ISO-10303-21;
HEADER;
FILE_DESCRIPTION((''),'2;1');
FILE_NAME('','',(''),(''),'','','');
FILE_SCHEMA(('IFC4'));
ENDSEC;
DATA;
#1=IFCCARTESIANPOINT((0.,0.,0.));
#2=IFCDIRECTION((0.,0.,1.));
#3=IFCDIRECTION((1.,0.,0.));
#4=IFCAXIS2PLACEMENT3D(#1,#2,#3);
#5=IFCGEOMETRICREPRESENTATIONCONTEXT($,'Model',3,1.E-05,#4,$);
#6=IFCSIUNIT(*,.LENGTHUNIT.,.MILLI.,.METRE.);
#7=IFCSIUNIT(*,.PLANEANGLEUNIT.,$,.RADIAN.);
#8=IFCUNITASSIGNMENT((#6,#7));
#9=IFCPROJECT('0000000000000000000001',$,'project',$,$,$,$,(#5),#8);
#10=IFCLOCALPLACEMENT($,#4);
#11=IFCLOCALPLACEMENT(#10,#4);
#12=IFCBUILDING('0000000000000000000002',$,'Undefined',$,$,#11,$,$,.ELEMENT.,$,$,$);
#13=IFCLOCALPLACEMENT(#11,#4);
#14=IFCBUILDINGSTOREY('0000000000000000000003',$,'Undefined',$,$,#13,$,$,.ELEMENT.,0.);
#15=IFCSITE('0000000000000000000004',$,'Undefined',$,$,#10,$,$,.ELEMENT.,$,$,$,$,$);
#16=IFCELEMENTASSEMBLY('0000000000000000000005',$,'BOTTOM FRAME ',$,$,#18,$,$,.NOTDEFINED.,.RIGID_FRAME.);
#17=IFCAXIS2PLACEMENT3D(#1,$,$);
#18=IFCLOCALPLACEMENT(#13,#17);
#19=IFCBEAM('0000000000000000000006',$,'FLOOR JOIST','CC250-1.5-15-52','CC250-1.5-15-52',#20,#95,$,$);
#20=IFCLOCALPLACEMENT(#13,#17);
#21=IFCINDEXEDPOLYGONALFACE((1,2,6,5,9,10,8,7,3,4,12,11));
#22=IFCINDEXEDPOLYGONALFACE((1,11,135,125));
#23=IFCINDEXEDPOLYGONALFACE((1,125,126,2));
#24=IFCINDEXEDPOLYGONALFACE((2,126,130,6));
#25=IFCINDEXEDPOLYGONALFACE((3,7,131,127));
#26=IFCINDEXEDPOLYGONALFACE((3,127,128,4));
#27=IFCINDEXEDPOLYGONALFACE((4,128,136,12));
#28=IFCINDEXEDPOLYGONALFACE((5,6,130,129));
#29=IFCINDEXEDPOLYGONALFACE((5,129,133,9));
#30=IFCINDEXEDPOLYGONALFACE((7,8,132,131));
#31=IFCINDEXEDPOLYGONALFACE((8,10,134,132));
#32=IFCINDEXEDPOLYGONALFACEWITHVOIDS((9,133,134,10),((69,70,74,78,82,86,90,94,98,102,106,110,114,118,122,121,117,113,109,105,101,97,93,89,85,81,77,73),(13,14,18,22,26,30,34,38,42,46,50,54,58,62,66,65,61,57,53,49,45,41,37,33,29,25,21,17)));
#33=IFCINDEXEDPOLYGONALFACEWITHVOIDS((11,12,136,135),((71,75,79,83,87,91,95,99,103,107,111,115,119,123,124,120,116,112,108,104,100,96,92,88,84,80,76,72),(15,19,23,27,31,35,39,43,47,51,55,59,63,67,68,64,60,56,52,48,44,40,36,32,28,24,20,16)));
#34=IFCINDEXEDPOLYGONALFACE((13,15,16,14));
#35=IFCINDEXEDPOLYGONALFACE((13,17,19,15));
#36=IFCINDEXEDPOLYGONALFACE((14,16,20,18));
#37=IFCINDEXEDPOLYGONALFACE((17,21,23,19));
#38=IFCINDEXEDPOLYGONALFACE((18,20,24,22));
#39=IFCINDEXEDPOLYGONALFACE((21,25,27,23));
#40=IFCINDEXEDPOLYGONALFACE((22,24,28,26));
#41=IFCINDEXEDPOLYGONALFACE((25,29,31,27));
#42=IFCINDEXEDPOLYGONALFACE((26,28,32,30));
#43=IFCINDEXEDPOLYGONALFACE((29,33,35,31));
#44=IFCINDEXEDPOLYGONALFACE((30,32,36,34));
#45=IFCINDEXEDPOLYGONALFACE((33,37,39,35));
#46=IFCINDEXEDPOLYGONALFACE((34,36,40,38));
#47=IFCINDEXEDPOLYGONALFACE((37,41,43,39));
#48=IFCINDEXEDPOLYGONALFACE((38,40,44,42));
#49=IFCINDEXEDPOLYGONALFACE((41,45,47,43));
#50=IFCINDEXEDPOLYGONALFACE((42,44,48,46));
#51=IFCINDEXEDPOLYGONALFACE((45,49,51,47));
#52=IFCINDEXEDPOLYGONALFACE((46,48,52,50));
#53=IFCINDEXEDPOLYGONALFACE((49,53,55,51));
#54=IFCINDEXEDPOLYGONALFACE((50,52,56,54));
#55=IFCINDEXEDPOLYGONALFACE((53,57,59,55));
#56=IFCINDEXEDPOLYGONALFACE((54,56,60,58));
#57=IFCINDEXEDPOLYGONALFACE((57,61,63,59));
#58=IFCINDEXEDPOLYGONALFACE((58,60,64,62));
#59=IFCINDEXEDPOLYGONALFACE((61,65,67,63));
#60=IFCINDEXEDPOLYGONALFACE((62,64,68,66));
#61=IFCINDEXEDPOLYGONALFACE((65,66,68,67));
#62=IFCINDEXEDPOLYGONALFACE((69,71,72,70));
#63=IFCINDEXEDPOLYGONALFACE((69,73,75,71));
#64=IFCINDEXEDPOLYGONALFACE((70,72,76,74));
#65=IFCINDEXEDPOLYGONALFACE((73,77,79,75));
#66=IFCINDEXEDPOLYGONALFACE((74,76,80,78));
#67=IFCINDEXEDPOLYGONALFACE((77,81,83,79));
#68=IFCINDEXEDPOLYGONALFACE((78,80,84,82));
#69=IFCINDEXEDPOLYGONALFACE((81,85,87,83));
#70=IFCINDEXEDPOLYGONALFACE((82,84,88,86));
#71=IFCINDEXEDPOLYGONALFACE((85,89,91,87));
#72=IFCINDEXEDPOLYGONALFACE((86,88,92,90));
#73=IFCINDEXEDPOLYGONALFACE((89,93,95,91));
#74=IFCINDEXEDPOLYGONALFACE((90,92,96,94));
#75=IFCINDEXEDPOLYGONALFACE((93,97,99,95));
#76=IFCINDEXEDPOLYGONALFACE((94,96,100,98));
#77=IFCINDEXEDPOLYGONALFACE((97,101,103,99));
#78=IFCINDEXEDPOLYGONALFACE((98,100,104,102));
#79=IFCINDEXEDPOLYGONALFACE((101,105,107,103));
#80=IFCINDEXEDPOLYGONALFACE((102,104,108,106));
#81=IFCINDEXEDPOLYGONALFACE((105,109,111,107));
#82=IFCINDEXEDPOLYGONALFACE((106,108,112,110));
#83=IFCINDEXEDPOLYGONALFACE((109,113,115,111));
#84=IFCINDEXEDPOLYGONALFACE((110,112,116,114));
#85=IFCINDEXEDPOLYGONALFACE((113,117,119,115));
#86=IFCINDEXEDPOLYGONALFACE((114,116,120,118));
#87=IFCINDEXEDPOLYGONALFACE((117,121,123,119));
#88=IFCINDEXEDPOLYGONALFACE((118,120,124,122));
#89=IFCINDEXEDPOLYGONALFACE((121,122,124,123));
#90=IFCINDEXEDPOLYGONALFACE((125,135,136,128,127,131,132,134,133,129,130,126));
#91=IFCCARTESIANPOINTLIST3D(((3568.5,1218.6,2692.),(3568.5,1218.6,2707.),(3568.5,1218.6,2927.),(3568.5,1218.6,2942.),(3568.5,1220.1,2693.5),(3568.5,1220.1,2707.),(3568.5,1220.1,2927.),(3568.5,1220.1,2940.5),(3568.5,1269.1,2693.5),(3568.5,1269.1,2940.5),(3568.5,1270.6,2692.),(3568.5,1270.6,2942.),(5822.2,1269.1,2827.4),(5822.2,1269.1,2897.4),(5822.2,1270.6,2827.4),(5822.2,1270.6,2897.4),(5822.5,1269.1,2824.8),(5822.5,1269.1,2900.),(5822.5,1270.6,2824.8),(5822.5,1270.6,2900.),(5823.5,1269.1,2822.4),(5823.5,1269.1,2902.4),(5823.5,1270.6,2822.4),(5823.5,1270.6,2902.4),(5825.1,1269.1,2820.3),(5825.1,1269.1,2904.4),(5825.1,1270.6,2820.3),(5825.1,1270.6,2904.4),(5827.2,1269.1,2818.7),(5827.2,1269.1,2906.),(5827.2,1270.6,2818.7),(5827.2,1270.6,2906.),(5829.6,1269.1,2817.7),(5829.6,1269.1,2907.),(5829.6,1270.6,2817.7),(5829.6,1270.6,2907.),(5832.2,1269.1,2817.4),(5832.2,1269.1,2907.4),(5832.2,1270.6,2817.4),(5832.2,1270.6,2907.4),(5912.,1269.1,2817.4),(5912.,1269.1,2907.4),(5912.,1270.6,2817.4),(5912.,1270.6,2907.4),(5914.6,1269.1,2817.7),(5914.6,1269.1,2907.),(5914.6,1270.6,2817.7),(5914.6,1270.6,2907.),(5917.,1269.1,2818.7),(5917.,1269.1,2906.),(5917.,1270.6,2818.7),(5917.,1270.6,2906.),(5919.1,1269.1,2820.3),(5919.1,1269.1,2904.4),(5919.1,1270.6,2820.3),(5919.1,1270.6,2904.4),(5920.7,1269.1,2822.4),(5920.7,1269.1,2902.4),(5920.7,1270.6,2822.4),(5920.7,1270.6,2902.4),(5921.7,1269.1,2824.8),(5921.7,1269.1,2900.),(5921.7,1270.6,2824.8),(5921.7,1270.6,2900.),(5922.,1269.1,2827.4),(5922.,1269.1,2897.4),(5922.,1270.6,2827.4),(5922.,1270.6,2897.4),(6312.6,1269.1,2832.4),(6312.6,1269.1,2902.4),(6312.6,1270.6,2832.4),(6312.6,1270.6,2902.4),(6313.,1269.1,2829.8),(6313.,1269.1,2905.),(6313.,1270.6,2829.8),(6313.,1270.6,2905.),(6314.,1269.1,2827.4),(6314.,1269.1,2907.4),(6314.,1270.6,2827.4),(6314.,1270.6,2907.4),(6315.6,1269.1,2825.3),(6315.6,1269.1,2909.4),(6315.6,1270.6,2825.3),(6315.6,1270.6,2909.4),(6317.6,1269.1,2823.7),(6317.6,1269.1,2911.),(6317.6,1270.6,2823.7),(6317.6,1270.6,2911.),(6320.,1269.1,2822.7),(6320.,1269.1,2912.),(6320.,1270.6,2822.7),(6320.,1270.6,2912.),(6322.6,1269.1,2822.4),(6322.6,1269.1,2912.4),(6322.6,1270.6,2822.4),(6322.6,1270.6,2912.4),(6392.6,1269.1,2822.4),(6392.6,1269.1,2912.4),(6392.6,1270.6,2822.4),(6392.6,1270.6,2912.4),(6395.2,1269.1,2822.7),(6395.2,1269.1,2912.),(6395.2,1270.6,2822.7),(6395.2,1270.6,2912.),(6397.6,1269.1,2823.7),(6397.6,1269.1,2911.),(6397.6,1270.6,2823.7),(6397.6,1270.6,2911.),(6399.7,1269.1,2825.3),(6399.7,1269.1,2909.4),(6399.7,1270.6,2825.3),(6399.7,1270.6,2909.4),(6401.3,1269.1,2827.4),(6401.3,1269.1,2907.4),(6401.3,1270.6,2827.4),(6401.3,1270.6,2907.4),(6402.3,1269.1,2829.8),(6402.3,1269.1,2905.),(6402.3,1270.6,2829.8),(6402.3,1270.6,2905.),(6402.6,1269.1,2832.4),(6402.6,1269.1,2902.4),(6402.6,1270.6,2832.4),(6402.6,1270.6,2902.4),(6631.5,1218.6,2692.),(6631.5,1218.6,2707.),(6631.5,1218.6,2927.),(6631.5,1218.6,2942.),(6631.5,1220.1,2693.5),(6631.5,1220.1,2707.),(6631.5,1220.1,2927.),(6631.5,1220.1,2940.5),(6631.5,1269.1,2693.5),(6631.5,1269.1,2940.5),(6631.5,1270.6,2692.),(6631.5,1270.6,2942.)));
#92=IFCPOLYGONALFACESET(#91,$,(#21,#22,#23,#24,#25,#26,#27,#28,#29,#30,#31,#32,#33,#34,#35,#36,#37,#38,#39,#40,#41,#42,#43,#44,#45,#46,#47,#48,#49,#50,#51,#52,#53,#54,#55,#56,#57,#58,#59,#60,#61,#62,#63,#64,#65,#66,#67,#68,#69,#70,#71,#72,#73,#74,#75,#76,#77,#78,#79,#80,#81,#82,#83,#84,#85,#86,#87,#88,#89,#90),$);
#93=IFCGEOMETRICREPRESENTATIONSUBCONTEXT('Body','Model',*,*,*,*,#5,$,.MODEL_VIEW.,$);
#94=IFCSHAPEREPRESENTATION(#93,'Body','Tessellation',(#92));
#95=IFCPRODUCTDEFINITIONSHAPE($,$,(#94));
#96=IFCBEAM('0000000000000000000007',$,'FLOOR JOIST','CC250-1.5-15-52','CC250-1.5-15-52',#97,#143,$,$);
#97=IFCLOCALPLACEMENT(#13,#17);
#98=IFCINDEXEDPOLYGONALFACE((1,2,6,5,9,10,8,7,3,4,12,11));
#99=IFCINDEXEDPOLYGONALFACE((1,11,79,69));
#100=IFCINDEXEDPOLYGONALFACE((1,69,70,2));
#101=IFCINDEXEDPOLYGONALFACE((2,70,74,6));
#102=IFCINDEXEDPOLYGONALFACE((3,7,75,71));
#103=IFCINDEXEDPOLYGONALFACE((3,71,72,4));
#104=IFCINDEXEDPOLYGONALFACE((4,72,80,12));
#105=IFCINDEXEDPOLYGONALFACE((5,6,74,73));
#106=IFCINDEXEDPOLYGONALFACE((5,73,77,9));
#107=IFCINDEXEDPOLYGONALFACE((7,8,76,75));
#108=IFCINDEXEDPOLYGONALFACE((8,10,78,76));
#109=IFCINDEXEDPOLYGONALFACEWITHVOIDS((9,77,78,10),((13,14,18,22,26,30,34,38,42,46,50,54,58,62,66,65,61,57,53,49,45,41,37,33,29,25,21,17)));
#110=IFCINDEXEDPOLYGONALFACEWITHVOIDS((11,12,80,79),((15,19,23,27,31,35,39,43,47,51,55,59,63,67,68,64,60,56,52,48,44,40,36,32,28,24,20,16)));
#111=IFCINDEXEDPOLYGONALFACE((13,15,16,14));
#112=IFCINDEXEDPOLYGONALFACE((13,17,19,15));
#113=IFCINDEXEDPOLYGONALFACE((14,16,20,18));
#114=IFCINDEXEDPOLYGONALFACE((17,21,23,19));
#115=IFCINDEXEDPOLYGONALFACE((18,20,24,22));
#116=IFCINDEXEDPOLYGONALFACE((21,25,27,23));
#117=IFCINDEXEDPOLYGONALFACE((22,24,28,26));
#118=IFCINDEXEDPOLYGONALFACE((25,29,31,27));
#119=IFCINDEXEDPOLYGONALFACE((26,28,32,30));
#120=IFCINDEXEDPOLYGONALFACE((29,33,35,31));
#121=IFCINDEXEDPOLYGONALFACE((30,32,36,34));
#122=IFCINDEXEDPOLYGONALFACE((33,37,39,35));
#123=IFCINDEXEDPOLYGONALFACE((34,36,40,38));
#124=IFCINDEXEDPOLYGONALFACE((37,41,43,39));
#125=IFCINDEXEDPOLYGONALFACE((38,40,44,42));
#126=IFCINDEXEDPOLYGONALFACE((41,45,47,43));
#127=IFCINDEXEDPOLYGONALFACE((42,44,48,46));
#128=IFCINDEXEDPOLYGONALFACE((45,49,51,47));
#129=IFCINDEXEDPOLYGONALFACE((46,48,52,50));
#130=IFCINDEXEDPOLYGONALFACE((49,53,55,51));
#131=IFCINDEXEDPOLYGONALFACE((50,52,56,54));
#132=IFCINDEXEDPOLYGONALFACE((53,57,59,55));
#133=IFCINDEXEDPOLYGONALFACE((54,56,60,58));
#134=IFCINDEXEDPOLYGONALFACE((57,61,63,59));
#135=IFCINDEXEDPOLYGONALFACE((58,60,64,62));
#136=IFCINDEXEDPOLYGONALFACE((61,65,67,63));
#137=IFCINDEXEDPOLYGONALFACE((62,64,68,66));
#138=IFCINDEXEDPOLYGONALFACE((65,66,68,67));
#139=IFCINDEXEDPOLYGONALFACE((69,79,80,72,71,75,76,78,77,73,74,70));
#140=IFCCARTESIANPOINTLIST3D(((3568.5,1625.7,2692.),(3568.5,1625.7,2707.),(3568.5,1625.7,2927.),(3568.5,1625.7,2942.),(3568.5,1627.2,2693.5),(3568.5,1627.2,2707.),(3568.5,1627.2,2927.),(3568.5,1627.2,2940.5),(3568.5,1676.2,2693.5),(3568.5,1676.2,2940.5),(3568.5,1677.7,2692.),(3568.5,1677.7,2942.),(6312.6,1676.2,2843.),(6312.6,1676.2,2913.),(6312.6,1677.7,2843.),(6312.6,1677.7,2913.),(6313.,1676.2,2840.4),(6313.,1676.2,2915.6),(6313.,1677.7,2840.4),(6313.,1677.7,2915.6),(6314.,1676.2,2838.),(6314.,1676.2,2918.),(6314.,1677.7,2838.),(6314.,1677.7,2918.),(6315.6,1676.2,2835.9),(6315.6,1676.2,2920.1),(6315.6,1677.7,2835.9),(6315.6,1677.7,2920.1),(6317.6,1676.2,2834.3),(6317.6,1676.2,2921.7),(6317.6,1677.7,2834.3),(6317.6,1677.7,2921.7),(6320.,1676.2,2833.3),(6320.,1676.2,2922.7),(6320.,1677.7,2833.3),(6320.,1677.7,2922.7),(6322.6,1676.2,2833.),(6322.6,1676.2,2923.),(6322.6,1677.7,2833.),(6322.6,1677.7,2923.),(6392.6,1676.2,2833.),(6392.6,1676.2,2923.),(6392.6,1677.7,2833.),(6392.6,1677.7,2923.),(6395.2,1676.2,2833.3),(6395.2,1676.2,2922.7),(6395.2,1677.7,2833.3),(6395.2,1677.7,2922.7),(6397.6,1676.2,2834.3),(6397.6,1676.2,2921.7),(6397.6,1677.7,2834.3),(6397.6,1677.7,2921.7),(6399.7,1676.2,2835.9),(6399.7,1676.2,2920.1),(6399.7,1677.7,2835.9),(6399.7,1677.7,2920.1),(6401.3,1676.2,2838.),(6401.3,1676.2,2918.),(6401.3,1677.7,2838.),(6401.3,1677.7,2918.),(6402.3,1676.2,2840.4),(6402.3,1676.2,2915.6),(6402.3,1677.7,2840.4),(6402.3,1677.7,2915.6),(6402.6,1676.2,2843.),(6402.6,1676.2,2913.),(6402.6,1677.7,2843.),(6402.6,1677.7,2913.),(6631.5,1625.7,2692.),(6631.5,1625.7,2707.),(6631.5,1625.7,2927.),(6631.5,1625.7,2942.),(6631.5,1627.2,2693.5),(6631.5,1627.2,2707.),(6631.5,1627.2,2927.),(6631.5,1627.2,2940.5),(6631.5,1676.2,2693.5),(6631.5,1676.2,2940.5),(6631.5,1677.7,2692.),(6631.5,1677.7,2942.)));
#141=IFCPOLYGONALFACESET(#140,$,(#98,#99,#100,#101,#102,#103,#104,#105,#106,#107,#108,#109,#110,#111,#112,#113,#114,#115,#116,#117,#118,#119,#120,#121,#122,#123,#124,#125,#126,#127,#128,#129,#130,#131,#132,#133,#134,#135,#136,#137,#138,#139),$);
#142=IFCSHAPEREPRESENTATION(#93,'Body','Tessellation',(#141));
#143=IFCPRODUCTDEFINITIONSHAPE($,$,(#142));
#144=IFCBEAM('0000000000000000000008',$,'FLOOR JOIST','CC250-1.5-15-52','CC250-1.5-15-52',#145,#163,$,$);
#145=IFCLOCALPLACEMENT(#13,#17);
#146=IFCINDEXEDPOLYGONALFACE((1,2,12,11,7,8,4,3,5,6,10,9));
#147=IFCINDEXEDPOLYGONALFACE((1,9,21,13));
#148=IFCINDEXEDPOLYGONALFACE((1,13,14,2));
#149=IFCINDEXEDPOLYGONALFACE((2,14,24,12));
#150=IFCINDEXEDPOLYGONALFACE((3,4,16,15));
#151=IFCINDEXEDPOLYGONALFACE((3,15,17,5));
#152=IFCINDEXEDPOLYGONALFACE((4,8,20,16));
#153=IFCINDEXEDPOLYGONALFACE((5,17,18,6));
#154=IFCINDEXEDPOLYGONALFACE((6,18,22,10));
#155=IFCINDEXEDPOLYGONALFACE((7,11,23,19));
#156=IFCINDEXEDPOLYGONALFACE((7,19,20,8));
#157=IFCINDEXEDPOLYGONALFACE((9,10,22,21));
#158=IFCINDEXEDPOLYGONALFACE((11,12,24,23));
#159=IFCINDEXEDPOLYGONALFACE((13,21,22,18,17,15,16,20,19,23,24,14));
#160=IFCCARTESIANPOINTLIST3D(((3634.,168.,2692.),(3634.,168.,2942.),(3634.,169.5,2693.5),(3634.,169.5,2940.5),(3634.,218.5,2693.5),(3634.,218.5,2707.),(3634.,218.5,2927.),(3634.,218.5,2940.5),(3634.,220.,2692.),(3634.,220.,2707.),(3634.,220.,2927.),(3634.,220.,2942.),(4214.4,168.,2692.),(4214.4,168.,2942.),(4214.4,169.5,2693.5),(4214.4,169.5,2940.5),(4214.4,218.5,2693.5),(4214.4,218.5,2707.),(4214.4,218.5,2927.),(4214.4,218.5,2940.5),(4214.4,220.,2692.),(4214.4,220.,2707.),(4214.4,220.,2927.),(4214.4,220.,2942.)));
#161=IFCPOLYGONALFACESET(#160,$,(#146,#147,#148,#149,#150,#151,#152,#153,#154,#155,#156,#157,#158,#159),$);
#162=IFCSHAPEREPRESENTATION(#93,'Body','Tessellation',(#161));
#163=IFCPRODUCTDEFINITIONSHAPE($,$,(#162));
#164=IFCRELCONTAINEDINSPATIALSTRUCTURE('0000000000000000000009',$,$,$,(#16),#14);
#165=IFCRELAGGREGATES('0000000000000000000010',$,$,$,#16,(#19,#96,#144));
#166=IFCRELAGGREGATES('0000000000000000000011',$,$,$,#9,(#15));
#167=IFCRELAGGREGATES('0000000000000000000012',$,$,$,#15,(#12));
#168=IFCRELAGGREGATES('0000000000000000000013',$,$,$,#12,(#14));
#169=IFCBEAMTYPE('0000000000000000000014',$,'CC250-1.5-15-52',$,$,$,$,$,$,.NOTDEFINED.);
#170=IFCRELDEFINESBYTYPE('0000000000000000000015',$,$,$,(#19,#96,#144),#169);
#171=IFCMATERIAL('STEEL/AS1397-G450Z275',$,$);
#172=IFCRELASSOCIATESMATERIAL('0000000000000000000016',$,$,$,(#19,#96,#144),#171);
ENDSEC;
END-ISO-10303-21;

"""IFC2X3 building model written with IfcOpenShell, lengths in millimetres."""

from ifc_helpers import new_model, si_unit, frame, frame_2d, origin_with_axes, origin_2d_with_axis, place, context, subcontext, project, spatial, polyline, circle_curve, parameter, trimmed, segment, composite_curve, c_section, outline, extrude, boolean, material, type_object, element, aggregate, save


model = new_model("IFC2X3")

# Units and contexts
model_context = context("Model", 3, precision=1e-05, world=origin_with_axes())
body_context = subcontext(model_context, "Body", "Model", "MODEL_VIEW")
ifc_project = project(units=[si_unit("LENGTHUNIT", "METRE", prefix="MILLI"), si_unit("PLANEANGLEUNIT", "RADIAN")], contexts=[model_context])

# Site, building, storey
site_placement = place(None, origin_with_axes())
site = spatial("IfcSite", under=ifc_project, at=site_placement, Name="Undefined", CompositionType="ELEMENT")
building_placement = place(site_placement, origin_with_axes())
building = spatial("IfcBuilding", under=site, at=building_placement, Name="Undefined", CompositionType="ELEMENT")
storey_placement = place(building_placement, origin_with_axes())
storey = spatial("IfcBuildingStorey", under=building, at=storey_placement, Name="Undefined", CompositionType="ELEMENT", Elevation=0.0)

# Element assembly, beams
assembly_1_placement = place(storey_placement, origin_with_axes())
assembly_1 = element("IfcElementAssembly", 1, at=assembly_1_placement, inside=storey, Name="BOTTOM FRAME ", AssemblyPlace="NOTDEFINED", PredefinedType="RIGID_FRAME")
ifc_material_1 = material(Name="STEEL/AS1397-G450Z275")
beam_type_1 = type_object("IfcBeamType", Name="CC250-1.5-15-52", PredefinedType="NOTDEFINED")
beam_1_placement = place(assembly_1_placement, frame((3568.5, 1244.6, 2817.0), z_axis=(0.0, 0.0, 1.0), x_axis=(1.0, 0.0, 0.0)))
beam_1 = element("IfcBeam", 2, at=beam_1_placement, type_object=beam_type_1, material=ifc_material_1, Name="FLOOR JOIST", Description="CC250-1.5-15-52", ObjectType="CC250-1.5-15-52", context=body_context, shape_type="CSG", body=[
    boolean("DIFFERENCE", boolean("DIFFERENCE", extrude(c_section(Depth=250.0, Width=52.0, WallThickness=1.5, Girth=15.0, at=origin_2d_with_axis()), frame((3063.0, 0.0, 0.0), z_axis=(-1.0, 0.0, 0.0), x_axis=(0.0, -1.0, 0.0)), (0.0, 0.0, 1.0), 3063.0), extrude(outline(composite_curve([segment(trimmed(circle_curve(frame_2d((10.0, 10.0), x_axis=(-1.0, 0.0)), 10.0), [parameter(0.0)], [parameter(1.570796)], True, "PARAMETER"), True, "CONTINUOUS"), segment(polyline([(10.0, 0.0), (89.8, 0.0)]), True, "CONTINUOUS"), segment(trimmed(circle_curve(frame_2d((89.8, 10.0), x_axis=(0.0, -1.0)), 10.0), [parameter(0.0)], [parameter(1.570796)], True, "PARAMETER"), True, "CONTINUOUS"), segment(polyline([(99.8, 10.0), (99.8, 80.0)]), True, "CONTINUOUS"), segment(trimmed(circle_curve(frame_2d((89.8, 80.0), x_axis=(1.0, 0.0)), 10.0), [parameter(0.0)], [parameter(1.570796)], True, "PARAMETER"), True, "CONTINUOUS"), segment(polyline([(89.8, 90.0), (10.0, 90.0)]), True, "CONTINUOUS"), segment(trimmed(circle_curve(frame_2d((10.0, 80.0), x_axis=(0.0, 1.0)), 10.0), [parameter(0.0)], [parameter(1.570796)], True, "PARAMETER"), True, "CONTINUOUS"), segment(polyline([(0.0, 80.0), (0.0, 10.0)]), True, "CONTINUOUS")], self_intersect=True)), frame((2253.7, -40.5, 90.4), z_axis=(0.0, 1.0, 0.0), x_axis=(1.0, 0.0, 0.0)), (0.0, 0.0, 1.0), 81.0)), extrude(outline(composite_curve([segment(trimmed(circle_curve(frame_2d((10.0, 10.0), x_axis=(-1.0, 0.0)), 10.0), [parameter(0.0)], [parameter(1.570796)], True, "PARAMETER"), True, "CONTINUOUS"), segment(polyline([(10.0, 0.0), (80.0, 0.0)]), True, "CONTINUOUS"), segment(trimmed(circle_curve(frame_2d((80.0, 10.0), x_axis=(0.0, -1.0)), 10.0), [parameter(0.0)], [parameter(1.570796)], True, "PARAMETER"), True, "CONTINUOUS"), segment(polyline([(90.0, 10.0), (90.0, 80.0)]), True, "CONTINUOUS"), segment(trimmed(circle_curve(frame_2d((80.0, 80.0), x_axis=(1.0, 0.0)), 10.0), [parameter(0.0)], [parameter(1.570796)], True, "PARAMETER"), True, "CONTINUOUS"), segment(polyline([(80.0, 90.0), (10.0, 90.0)]), True, "CONTINUOUS"), segment(trimmed(circle_curve(frame_2d((10.0, 80.0), x_axis=(0.0, 1.0)), 10.0), [parameter(0.0)], [parameter(1.570796)], True, "PARAMETER"), True, "CONTINUOUS"), segment(polyline([(0.0, 80.0), (0.0, 10.0)]), True, "CONTINUOUS")], self_intersect=True)), frame((2744.1, -40.5, 95.4), z_axis=(0.0, 1.0, 0.0), x_axis=(1.0, 0.0, 0.0)), (0.0, 0.0, 1.0), 81.0)),
])
beam_2_placement = place(assembly_1_placement, frame((3568.5, 1651.7, 2817.0), z_axis=(0.0, 0.0, 1.0), x_axis=(1.0, 0.0, 0.0)))
beam_2 = element("IfcBeam", 3, at=beam_2_placement, type_object=beam_type_1, material=ifc_material_1, Name="FLOOR JOIST", Description="CC250-1.5-15-52", ObjectType="CC250-1.5-15-52", context=body_context, shape_type="CSG", body=[
    boolean("DIFFERENCE", extrude(c_section(Depth=250.0, Width=52.0, WallThickness=1.5, Girth=15.0, at=origin_2d_with_axis()), frame((3063.0, 0.0, 0.0), z_axis=(-1.0, 0.0, 0.0), x_axis=(0.0, -1.0, 0.0)), (0.0, 0.0, 1.0), 3063.0), extrude(outline(composite_curve([segment(trimmed(circle_curve(frame_2d((10.0, 10.0), x_axis=(-1.0, 0.0)), 10.0), [parameter(0.0)], [parameter(1.570796)], True, "PARAMETER"), True, "CONTINUOUS"), segment(polyline([(10.0, 0.0), (80.0, 0.0)]), True, "CONTINUOUS"), segment(trimmed(circle_curve(frame_2d((80.0, 10.0), x_axis=(0.0, -1.0)), 10.0), [parameter(0.0)], [parameter(1.570796)], True, "PARAMETER"), True, "CONTINUOUS"), segment(polyline([(90.0, 10.0), (90.0, 80.0)]), True, "CONTINUOUS"), segment(trimmed(circle_curve(frame_2d((80.0, 80.0), x_axis=(1.0, 0.0)), 10.0), [parameter(0.0)], [parameter(1.570796)], True, "PARAMETER"), True, "CONTINUOUS"), segment(polyline([(80.0, 90.0), (10.0, 90.0)]), True, "CONTINUOUS"), segment(trimmed(circle_curve(frame_2d((10.0, 80.0), x_axis=(0.0, 1.0)), 10.0), [parameter(0.0)], [parameter(1.570796)], True, "PARAMETER"), True, "CONTINUOUS"), segment(polyline([(0.0, 80.0), (0.0, 10.0)]), True, "CONTINUOUS")], self_intersect=True)), frame((2744.1, -40.5, 106.0), z_axis=(0.0, 1.0, 0.0), x_axis=(1.0, 0.0, 0.0)), (0.0, 0.0, 1.0), 81.0)),
])
beam_3_placement = place(assembly_1_placement, frame((4214.4, 194.0, 2817.0), z_axis=(0.0, 0.0, 1.0), x_axis=(-1.0, 0.0, 0.0)))
beam_3 = element("IfcBeam", 4, at=beam_3_placement, type_object=beam_type_1, material=ifc_material_1, Name="FLOOR JOIST", Description="CC250-1.5-15-52", ObjectType="CC250-1.5-15-52", context=body_context, shape_type="SweptSolid", body=[
    extrude(c_section(Depth=250.0, Width=52.0, WallThickness=1.5, Girth=15.0, at=origin_2d_with_axis()), frame((580.4, 0.0, 0.0), z_axis=(-1.0, 0.0, 0.0), x_axis=(0.0, -1.0, 0.0)), (0.0, 0.0, 1.0), 580.4),
])

aggregate(assembly_1, [beam_1, beam_2, beam_3])

save(model, "model.ifc")
